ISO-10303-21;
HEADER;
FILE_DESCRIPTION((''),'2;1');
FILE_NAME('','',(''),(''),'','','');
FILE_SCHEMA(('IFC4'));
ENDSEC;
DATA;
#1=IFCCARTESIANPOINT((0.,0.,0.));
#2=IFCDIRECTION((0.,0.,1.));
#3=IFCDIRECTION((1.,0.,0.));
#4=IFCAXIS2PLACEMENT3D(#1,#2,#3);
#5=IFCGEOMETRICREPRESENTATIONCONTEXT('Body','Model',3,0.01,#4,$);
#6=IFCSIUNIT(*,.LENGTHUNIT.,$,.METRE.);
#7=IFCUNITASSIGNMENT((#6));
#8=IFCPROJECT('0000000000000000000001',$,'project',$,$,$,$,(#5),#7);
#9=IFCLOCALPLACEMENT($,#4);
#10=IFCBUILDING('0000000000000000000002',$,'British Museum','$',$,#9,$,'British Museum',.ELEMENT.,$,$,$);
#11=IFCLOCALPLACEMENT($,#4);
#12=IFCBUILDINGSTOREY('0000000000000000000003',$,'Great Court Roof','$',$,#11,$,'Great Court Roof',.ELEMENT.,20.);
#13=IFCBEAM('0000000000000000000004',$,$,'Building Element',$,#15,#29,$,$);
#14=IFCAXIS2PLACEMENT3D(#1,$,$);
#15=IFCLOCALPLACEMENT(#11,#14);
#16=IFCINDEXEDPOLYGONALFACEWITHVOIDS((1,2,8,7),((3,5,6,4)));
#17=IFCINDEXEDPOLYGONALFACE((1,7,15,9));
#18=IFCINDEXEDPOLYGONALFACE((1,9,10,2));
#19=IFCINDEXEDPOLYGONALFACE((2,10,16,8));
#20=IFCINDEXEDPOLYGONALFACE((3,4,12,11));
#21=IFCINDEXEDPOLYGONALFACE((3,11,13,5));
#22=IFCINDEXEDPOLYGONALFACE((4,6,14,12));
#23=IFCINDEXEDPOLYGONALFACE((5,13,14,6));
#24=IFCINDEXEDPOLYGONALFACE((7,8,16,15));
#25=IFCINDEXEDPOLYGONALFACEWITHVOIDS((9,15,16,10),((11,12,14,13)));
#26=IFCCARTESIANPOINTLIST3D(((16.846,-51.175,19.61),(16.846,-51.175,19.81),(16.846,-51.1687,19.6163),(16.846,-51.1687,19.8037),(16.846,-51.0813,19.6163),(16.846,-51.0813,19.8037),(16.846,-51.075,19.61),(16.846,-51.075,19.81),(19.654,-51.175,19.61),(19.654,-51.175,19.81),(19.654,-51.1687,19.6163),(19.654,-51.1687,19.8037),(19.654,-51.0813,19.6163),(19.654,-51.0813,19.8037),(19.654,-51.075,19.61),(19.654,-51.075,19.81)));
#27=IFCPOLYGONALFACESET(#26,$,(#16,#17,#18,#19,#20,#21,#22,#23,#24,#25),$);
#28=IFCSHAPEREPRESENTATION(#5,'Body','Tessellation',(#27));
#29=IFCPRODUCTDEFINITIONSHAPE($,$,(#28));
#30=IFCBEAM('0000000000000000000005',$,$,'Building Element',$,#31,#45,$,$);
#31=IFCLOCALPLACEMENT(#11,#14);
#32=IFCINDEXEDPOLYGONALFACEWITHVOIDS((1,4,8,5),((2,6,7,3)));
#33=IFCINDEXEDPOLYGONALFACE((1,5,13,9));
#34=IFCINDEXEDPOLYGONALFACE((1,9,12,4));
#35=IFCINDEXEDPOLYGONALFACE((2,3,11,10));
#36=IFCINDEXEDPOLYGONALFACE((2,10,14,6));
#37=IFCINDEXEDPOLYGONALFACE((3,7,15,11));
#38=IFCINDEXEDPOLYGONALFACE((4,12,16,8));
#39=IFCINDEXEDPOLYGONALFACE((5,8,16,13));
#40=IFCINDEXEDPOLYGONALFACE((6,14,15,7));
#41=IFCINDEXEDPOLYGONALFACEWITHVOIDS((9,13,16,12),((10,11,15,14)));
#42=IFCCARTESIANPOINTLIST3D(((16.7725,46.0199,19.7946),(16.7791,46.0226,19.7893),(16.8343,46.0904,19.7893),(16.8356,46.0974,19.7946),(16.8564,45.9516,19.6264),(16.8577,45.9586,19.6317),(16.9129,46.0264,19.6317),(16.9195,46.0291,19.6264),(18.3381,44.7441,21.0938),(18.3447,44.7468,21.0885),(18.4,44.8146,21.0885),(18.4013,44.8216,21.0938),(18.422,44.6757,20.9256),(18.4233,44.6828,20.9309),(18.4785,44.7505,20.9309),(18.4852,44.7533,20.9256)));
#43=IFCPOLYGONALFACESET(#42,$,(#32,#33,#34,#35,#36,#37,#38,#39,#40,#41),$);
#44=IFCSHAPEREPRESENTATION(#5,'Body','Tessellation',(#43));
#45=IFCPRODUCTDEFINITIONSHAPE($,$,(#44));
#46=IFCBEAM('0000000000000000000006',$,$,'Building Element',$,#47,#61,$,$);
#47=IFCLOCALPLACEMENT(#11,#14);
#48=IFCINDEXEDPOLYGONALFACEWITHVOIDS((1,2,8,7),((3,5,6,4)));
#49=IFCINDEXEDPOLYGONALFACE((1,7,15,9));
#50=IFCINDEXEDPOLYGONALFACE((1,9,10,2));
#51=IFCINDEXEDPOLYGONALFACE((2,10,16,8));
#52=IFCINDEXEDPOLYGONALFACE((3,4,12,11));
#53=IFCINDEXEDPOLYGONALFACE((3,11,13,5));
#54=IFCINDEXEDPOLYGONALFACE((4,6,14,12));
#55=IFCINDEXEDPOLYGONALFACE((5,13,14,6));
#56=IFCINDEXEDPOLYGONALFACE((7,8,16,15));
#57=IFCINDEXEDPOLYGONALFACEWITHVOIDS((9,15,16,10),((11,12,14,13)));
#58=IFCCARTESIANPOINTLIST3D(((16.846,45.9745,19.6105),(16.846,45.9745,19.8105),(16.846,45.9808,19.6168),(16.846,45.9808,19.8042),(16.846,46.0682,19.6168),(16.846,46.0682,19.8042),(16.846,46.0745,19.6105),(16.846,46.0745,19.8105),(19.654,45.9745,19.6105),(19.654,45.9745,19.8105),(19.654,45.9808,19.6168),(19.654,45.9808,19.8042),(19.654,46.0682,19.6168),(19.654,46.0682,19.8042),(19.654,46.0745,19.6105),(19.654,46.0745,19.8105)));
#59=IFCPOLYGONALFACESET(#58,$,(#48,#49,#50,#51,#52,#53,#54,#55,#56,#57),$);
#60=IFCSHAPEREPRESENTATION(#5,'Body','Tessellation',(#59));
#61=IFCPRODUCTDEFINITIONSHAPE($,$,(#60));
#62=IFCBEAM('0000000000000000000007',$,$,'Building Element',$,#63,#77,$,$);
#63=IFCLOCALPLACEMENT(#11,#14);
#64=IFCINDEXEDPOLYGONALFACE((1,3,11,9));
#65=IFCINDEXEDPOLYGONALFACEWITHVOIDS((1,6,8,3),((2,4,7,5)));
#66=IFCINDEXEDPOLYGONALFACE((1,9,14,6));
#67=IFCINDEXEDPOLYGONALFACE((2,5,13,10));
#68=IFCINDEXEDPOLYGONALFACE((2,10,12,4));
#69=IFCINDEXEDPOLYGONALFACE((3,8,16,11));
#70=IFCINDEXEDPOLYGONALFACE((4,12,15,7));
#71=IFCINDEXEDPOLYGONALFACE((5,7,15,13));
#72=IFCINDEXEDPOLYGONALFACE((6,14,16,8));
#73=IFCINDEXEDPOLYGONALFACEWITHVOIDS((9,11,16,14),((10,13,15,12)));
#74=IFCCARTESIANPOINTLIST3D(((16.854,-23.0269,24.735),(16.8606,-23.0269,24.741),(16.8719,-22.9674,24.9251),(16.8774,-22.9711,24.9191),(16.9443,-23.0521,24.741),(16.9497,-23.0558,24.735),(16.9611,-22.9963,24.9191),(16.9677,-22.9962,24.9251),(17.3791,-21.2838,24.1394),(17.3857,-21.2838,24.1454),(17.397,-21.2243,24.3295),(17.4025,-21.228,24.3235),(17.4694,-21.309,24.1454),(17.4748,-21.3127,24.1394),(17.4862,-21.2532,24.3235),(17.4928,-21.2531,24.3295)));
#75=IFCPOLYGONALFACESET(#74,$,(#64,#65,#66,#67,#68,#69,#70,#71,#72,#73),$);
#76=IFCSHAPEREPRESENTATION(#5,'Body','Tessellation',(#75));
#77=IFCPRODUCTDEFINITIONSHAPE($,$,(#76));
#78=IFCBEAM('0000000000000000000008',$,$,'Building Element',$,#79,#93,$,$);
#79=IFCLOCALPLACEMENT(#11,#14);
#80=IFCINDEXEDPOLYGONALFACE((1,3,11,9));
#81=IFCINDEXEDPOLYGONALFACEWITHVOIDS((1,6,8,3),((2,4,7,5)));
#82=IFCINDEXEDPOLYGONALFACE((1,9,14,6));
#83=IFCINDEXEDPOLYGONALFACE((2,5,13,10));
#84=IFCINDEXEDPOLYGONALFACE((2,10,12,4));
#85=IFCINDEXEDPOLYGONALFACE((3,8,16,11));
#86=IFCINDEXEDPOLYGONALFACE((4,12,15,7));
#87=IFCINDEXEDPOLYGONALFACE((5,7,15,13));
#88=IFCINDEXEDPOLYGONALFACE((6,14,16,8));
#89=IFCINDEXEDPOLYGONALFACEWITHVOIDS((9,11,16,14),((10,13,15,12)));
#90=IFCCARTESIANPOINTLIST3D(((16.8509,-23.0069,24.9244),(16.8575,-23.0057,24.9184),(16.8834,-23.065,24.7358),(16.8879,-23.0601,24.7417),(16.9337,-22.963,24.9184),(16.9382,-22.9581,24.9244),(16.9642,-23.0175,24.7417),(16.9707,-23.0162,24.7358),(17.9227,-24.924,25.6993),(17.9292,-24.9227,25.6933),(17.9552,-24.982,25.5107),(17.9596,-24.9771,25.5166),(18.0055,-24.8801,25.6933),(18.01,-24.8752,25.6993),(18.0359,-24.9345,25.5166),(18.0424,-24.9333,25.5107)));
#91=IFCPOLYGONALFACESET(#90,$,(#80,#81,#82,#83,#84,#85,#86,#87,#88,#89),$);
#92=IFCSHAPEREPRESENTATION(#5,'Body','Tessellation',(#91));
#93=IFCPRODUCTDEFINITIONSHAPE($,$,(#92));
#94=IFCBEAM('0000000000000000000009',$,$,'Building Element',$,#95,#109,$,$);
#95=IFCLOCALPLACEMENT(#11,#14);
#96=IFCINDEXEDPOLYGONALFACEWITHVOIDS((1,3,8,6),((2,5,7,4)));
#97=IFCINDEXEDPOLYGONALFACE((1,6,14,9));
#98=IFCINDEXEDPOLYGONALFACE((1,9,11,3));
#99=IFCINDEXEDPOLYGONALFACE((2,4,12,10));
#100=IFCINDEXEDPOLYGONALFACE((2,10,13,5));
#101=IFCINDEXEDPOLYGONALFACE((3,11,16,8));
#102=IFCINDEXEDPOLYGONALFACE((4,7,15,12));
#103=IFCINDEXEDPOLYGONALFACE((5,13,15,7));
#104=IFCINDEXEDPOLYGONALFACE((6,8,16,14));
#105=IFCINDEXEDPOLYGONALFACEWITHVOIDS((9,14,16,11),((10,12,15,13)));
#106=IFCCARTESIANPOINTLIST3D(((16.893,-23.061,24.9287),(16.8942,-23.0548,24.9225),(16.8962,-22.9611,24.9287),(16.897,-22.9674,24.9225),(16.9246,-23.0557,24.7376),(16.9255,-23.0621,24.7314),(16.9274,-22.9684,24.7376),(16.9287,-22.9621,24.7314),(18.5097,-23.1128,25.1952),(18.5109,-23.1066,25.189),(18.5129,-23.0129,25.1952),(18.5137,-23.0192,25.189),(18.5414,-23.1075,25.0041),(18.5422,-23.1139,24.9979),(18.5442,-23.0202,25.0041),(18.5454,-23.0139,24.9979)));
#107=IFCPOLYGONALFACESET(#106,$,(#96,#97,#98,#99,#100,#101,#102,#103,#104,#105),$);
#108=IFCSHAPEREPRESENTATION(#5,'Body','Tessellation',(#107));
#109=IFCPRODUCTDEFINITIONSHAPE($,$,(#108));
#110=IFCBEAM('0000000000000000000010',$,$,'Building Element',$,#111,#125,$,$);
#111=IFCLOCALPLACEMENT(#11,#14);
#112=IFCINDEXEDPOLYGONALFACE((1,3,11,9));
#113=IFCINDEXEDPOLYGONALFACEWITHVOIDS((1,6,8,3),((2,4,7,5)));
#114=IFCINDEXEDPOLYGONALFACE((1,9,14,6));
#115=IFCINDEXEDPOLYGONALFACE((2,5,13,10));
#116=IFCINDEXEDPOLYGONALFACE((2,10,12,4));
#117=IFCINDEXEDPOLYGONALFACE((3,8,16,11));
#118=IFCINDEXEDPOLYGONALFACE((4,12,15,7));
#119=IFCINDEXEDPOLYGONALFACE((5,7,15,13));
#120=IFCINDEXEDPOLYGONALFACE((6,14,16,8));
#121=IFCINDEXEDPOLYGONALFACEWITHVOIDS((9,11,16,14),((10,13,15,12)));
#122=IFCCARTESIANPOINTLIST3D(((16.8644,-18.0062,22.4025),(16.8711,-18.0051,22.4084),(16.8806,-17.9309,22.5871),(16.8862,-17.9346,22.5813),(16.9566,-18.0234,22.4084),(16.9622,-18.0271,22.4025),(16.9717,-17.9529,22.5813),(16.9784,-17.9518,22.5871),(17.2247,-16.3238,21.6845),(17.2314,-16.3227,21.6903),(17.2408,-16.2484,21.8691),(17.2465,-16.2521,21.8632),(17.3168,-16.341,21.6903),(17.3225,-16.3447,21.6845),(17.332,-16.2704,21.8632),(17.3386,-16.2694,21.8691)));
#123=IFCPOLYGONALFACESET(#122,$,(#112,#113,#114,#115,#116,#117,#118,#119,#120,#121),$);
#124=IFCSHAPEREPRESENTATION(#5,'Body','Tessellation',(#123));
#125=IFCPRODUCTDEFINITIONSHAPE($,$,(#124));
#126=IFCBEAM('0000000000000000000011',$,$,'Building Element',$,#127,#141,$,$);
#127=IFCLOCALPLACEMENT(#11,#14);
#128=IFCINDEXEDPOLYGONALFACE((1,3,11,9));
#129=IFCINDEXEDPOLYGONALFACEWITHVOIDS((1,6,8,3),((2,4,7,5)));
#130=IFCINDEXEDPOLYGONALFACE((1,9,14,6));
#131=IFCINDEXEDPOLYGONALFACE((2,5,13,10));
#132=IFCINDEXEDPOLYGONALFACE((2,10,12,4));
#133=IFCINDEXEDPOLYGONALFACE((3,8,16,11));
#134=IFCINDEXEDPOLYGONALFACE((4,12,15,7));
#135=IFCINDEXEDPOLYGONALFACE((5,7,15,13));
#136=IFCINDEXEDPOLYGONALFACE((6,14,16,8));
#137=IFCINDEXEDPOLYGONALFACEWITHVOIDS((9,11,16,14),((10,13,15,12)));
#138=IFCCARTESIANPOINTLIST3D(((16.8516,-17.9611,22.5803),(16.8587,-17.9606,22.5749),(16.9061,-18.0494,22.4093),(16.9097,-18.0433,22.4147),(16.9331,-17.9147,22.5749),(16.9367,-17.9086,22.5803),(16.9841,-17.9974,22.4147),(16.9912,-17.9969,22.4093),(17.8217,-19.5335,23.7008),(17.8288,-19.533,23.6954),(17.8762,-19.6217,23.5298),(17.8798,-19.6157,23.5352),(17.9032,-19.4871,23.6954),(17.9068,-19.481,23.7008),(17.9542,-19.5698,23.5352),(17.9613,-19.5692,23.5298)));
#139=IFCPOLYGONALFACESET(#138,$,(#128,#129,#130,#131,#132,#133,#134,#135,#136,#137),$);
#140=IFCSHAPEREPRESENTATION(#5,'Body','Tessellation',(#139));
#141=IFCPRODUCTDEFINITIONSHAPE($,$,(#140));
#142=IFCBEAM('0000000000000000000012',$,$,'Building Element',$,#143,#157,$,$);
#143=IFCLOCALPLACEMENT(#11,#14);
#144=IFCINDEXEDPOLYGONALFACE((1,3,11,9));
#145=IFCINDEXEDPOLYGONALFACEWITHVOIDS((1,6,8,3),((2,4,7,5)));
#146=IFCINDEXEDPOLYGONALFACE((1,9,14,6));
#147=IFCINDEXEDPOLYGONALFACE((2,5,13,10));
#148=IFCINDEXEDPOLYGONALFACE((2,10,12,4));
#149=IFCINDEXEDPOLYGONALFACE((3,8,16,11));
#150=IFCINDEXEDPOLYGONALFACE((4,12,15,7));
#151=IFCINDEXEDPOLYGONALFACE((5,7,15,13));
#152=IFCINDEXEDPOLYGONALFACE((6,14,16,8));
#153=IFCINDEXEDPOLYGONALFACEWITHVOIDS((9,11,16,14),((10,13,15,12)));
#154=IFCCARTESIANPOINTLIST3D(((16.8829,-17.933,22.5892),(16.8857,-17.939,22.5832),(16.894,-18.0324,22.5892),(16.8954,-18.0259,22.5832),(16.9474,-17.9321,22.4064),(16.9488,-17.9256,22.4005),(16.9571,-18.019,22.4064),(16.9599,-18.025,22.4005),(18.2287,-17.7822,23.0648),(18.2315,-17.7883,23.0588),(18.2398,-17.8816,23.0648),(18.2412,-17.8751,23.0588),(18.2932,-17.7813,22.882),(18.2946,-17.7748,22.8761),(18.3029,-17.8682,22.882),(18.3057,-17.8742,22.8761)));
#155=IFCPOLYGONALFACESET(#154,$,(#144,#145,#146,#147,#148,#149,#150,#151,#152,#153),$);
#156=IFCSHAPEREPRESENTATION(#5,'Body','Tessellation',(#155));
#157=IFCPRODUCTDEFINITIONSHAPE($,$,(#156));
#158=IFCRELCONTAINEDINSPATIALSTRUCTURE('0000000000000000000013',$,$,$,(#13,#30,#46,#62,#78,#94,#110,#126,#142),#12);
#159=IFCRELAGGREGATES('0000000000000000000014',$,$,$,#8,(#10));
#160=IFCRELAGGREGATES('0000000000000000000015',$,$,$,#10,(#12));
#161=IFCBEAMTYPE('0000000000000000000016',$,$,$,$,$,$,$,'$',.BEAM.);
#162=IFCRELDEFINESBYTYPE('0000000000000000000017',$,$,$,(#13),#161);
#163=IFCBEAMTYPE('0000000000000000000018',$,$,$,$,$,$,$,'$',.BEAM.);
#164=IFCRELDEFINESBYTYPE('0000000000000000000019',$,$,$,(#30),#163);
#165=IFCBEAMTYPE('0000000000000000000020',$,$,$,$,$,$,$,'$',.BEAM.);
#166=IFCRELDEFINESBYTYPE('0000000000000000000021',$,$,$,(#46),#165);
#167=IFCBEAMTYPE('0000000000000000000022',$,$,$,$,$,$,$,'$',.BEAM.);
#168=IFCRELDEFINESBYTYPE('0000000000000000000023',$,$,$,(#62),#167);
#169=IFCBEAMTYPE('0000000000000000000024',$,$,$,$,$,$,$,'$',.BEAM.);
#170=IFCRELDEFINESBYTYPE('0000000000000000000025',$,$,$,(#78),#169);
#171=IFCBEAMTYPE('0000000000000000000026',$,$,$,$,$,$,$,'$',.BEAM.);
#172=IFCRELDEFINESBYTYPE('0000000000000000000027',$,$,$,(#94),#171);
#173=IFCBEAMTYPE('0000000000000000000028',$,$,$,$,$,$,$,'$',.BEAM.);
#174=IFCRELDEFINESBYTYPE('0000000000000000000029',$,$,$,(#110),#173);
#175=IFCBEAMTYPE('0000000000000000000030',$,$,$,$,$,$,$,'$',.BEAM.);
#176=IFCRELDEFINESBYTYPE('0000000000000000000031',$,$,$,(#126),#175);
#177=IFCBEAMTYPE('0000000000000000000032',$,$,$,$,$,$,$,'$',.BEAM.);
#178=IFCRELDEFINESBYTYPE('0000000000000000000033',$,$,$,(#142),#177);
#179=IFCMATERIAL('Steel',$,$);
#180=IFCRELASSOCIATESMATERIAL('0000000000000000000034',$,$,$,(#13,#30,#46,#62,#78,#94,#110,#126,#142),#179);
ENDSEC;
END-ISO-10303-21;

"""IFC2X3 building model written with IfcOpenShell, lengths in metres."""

from ifc_helpers import new_model, si_unit, frame, origin_with_axes, origin_2d, place, context, project, spatial, hollow_rectangle, extrude, material, type_object, element, save


model = new_model("IFC2X3")

# Units and contexts
model_context = context("Model", 3, precision=0.01, world=origin_with_axes(), identifier="Body")
ifc_project = project(units=[si_unit("LENGTHUNIT", "METRE")], contexts=[model_context])

# Building, storey
building_placement = place(None, origin_with_axes())
building = spatial("IfcBuilding", under=ifc_project, at=building_placement, Name="British Museum", Description="$", LongName="British Museum", CompositionType="ELEMENT")
storey_placement = place(None, origin_with_axes())
storey = spatial("IfcBuildingStorey", under=building, at=storey_placement, Name="Great Court Roof", Description="$", LongName="Great Court Roof", CompositionType="ELEMENT", Elevation=20.0)

# Beams
ifc_material = material(Name="Steel")
beam_type_1 = type_object("IfcBeamType", ElementType="$", PredefinedType="BEAM")
beam_1_placement = place(None, origin_with_axes())
element("IfcBeam", 1, at=beam_1_placement, inside=storey, type_object=beam_type_1, material=ifc_material, Description="Building Element", context=model_context, shape_type="SweptSolid", body=[
    extrude(hollow_rectangle(XDim=0.1, YDim=0.2, WallThickness=0.0063, InnerFilletRadius=0.0, OuterFilletRadius=0.0, at=origin_2d()), frame((16.846, -51.125, 19.71), z_axis=(1.0, 0.0, 0.0), x_axis=(0.0, 1.0, 0.0)), (0.0, 0.0, 1.0), 2.808),
])
beam_type_2 = type_object("IfcBeamType", ElementType="$", PredefinedType="BEAM")
beam_2_placement = place(None, origin_with_axes())
element("IfcBeam", 2, at=beam_2_placement, inside=storey, type_object=beam_type_2, material=ifc_material, Description="Building Element", context=model_context, shape_type="SweptSolid", body=[
    extrude(hollow_rectangle(XDim=0.1, YDim=0.2, WallThickness=0.0063, InnerFilletRadius=0.0, OuterFilletRadius=0.0, at=origin_2d()), frame((16.846, 46.0245, 19.7105), z_axis=(0.651974, -0.531285, 0.540986), x_axis=(0.631707, 0.775207, 0.0)), (0.0, 0.0, 1.0), 2.4014),
])
beam_type_3 = type_object("IfcBeamType", ElementType="$", PredefinedType="BEAM")
beam_3_placement = place(None, origin_with_axes())
element("IfcBeam", 3, at=beam_3_placement, inside=storey, type_object=beam_type_3, material=ifc_material, Description="Building Element", context=model_context, shape_type="SweptSolid", body=[
    extrude(hollow_rectangle(XDim=0.1, YDim=0.2, WallThickness=0.0063, InnerFilletRadius=0.0, OuterFilletRadius=0.0, at=origin_2d()), frame((16.846, 46.0245, 19.7105), z_axis=(1.0, 0.0, -0.000009), x_axis=(0.0, 1.0, 0.0)), (0.0, 0.0, 1.0), 2.808),
])
beam_type_4 = type_object("IfcBeamType", ElementType="$", PredefinedType="BEAM")
beam_4_placement = place(None, origin_with_axes())
element("IfcBeam", 4, at=beam_4_placement, inside=storey, type_object=beam_type_4, material=ifc_material, Description="Building Element", context=model_context, shape_type="SweptSolid", body=[
    extrude(hollow_rectangle(XDim=0.1, YDim=0.2, WallThickness=0.0063, InnerFilletRadius=0.0, OuterFilletRadius=0.0, at=origin_2d()), frame((16.9108, -23.0116, 24.8301), z_axis=(0.274145, 0.910029, -0.310953), x_axis=(-0.957497, 0.288444, 0.0)), (0.0, 0.0, 1.0), 1.9154),
])
beam_type_5 = type_object("IfcBeamType", ElementType="$", PredefinedType="BEAM")
beam_5_placement = place(None, origin_with_axes())
element("IfcBeam", 5, at=beam_5_placement, inside=storey, type_object=beam_type_5, material=ifc_material, Description="Building Element", context=model_context, shape_type="SweptSolid", body=[
    extrude(hollow_rectangle(XDim=0.1, YDim=0.2, WallThickness=0.0063, InnerFilletRadius=0.0, OuterFilletRadius=0.0, at=origin_2d()), frame((16.9108, -23.0116, 24.8301), z_axis=(0.460176, -0.823123, 0.332724), x_axis=(0.872855, 0.487979, 0.0)), (0.0, 0.0, 1.0), 2.329),
])
beam_type_6 = type_object("IfcBeamType", ElementType="$", PredefinedType="BEAM")
beam_6_placement = place(None, origin_with_axes())
element("IfcBeam", 6, at=beam_6_placement, inside=storey, type_object=beam_type_6, material=ifc_material, Description="Building Element", context=model_context, shape_type="SweptSolid", body=[
    extrude(hollow_rectangle(XDim=0.1, YDim=0.2, WallThickness=0.0063, InnerFilletRadius=0.0, OuterFilletRadius=0.0, at=origin_2d()), frame((16.9108, -23.0116, 24.8301), z_axis=(0.986195, -0.031598, 0.162543), x_axis=(0.032024, 0.999487, 0.0)), (0.0, 0.0, 1.0), 1.6394),
])
beam_type_7 = type_object("IfcBeamType", ElementType="$", PredefinedType="BEAM")
beam_7_placement = place(None, origin_with_axes())
element("IfcBeam", 7, at=beam_7_placement, inside=storey, type_object=beam_type_7, material=ifc_material, Description="Building Element", context=model_context, shape_type="SweptSolid", body=[
    extrude(hollow_rectangle(XDim=0.1, YDim=0.2, WallThickness=0.0063, InnerFilletRadius=0.0, OuterFilletRadius=0.0, at=origin_2d()), frame((16.9214, -17.979, 22.4948), z_axis=(0.19324, 0.9024, -0.38514), x_axis=(-0.977832, 0.209393, 0.0)), (0.0, 0.0, 1.0), 1.8644),
])
beam_type_8 = type_object("IfcBeamType", ElementType="$", PredefinedType="BEAM")
beam_8_placement = place(None, origin_with_axes())
element("IfcBeam", 8, at=beam_8_placement, inside=storey, type_object=beam_type_8, material=ifc_material, Description="Building Element", context=model_context, shape_type="SweptSolid", body=[
    extrude(hollow_rectangle(XDim=0.1, YDim=0.2, WallThickness=0.0063, InnerFilletRadius=0.0, OuterFilletRadius=0.0, at=origin_2d()), frame((16.9214, -17.979, 22.4948), z_axis=(0.44896, -0.72769, 0.518557), x_axis=(0.851057, 0.525073, 0.0)), (0.0, 0.0, 1.0), 2.1608),
])
beam_type_9 = type_object("IfcBeamType", ElementType="$", PredefinedType="BEAM")
beam_9_placement = place(None, origin_with_axes())
element("IfcBeam", 9, at=beam_9_placement, inside=storey, type_object=beam_type_9, material=ifc_material, Description="Building Element", context=model_context, shape_type="SweptSolid", body=[
    extrude(hollow_rectangle(XDim=0.1, YDim=0.2, WallThickness=0.0063, InnerFilletRadius=0.0, OuterFilletRadius=0.0, at=origin_2d()), frame((16.9214, -17.979, 22.4948), z_axis=(0.937639, 0.105051, 0.331356), x_axis=(-0.111341, 0.993782, 0.0)), (0.0, 0.0, 1.0), 1.4353),
])

save(model, "model.ifc")
